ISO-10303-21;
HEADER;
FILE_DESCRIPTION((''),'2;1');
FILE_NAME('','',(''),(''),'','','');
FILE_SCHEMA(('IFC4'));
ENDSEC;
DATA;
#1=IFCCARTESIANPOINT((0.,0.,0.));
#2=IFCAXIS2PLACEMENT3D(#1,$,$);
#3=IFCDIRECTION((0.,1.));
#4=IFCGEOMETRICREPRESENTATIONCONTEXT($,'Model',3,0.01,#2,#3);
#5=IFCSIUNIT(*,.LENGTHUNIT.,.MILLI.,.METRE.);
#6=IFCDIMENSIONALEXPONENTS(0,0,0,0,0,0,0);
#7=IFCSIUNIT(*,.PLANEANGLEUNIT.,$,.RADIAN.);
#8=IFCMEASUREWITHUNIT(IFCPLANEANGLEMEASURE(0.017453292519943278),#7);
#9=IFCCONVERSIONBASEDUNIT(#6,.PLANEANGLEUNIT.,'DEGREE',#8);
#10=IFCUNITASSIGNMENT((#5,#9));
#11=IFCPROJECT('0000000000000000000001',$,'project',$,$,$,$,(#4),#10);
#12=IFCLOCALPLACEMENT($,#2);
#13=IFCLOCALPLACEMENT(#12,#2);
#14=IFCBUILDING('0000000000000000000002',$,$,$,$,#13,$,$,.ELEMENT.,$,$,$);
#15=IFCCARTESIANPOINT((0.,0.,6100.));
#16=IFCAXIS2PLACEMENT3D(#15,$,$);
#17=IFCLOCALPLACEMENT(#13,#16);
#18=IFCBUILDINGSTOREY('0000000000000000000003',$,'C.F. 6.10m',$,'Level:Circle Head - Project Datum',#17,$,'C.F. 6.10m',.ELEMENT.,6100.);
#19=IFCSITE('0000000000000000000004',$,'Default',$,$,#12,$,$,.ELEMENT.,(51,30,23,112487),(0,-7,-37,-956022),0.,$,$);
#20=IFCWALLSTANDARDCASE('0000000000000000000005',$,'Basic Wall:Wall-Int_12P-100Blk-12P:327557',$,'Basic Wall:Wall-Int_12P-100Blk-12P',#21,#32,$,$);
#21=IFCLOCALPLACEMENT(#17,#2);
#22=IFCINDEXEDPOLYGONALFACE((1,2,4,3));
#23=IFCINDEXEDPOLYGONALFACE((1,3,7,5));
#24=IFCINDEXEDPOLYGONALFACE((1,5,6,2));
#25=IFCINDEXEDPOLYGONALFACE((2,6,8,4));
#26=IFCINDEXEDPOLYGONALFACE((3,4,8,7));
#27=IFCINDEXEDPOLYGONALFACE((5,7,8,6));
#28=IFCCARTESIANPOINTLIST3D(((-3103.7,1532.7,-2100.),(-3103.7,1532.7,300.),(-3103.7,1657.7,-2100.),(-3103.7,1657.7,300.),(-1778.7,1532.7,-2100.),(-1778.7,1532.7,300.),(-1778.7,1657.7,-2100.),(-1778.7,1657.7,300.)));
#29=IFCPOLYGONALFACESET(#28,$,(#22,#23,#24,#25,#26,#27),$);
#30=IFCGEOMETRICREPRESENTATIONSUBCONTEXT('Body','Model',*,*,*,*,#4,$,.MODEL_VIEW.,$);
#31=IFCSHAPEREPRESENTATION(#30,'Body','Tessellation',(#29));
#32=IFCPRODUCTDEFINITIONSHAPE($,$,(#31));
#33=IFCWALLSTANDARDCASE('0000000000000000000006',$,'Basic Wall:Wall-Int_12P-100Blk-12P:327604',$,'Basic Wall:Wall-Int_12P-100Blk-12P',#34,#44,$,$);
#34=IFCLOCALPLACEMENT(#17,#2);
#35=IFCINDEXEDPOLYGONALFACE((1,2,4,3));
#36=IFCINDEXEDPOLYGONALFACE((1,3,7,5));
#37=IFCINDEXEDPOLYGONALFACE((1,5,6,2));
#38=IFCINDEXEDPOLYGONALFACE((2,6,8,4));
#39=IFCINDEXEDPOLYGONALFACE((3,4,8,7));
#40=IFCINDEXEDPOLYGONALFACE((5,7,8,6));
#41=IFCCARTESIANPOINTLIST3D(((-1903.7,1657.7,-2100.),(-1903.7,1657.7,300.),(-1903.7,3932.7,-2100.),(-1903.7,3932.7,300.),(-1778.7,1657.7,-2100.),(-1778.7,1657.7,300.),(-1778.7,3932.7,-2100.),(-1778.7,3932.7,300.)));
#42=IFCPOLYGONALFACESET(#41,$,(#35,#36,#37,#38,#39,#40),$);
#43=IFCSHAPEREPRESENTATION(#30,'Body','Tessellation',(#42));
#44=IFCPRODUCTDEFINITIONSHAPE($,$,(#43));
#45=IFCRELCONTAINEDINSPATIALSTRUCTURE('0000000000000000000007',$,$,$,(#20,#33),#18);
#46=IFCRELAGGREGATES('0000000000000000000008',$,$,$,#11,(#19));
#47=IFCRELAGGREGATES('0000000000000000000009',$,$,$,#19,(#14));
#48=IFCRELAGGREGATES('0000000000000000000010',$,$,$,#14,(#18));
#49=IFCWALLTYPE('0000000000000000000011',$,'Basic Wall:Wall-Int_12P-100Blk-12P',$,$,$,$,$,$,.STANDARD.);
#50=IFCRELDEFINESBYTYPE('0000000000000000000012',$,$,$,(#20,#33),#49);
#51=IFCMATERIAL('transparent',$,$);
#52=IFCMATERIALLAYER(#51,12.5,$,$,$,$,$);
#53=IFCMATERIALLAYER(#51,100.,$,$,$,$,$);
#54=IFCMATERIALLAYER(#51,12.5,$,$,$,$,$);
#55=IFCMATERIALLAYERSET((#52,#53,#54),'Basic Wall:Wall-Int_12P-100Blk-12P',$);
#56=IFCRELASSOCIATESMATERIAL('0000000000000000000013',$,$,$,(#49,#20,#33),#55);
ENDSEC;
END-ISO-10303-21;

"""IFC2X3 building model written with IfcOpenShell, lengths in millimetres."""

from ifc_helpers import new_model, entity, si_unit, converted_unit, direction, frame, frame_2d, origin, place, context, subcontext, project, spatial, rectangle, extrude, material, layer, layer_set, layer_usage, type_object, element, save


model = new_model("IFC2X3")

# Units and contexts
model_context = context("Model", 3, precision=0.01, world=origin(), true_north=direction((0.0, 1.0)))
body_context = subcontext(model_context, "Body", "Model", "MODEL_VIEW")
ifc_project = project(units=[si_unit("LENGTHUNIT", "METRE", prefix="MILLI"), converted_unit("PLANEANGLEUNIT", "DEGREE", entity("IfcPlaneAngleMeasure", 0.017453292519943278), si_unit("PLANEANGLEUNIT", "RADIAN"), dimensions=[0, 0, 0, 0, 0, 0, 0])], contexts=[model_context])

# Site, building, storey
site_placement = place(None, origin())
site = spatial("IfcSite", under=ifc_project, at=site_placement, Name="Default", CompositionType="ELEMENT", RefLatitude=(51, 30, 23, 112487), RefLongitude=(0, -7, -37, -956022), RefElevation=0.0)
building_placement = place(site_placement, origin())
building = spatial("IfcBuilding", under=site, at=building_placement, CompositionType="ELEMENT")
storey_placement = place(building_placement, frame((0.0, 0.0, 6100.0)))
storey = spatial("IfcBuildingStorey", under=building, at=storey_placement, Name="C.F. 6.10m", ObjectType="Level:Circle Head - Project Datum", LongName="C.F. 6.10m", CompositionType="ELEMENT", Elevation=6100.0)

# Walls
ifc_material = material(Name="transparent")
ifc_layer_1 = layer(ifc_material, 12.5)
ifc_layer_2 = layer(ifc_material, 100.0)
ifc_layer_3 = layer(ifc_material, 12.5)
ifc_layer_set = layer_set([ifc_layer_1, ifc_layer_2, ifc_layer_3], Name="Basic Wall:Wall-Int_12P-100Blk-12P")
ifc_layer_usage_1 = layer_usage(ifc_layer_set, "AXIS2", "NEGATIVE", 62.5)
wall_type = type_object("IfcWallType", Name="Basic Wall:Wall-Int_12P-100Blk-12P", PredefinedType="STANDARD", material=ifc_layer_set)
wall_1_placement = place(storey_placement, frame((-3103.7, 1595.2, -2100.0)))
element("IfcWallStandardCase", 1, at=wall_1_placement, inside=storey, type_object=wall_type, material=ifc_layer_usage_1, Name="Basic Wall:Wall-Int_12P-100Blk-12P:327557", ObjectType="Basic Wall:Wall-Int_12P-100Blk-12P", context=body_context, shape_type="SweptSolid", body=[
    extrude(rectangle(XDim=1325.0, YDim=125.0, at=frame_2d((662.5, 0.0), x_axis=(-1.0, 0.0))), origin(), (0.0, 0.0, 1.0), 2400.0),
])
ifc_layer_usage_2 = layer_usage(ifc_layer_set, "AXIS2", "NEGATIVE", 62.5)
wall_2_placement = place(storey_placement, frame((-1841.2, 1657.7, -2100.0), z_axis=(0.0, 0.0, 1.0), x_axis=(0.0, 1.0, 0.0)))
element("IfcWallStandardCase", 2, at=wall_2_placement, inside=storey, type_object=wall_type, material=ifc_layer_usage_2, Name="Basic Wall:Wall-Int_12P-100Blk-12P:327604", ObjectType="Basic Wall:Wall-Int_12P-100Blk-12P", context=body_context, shape_type="SweptSolid", body=[
    extrude(rectangle(XDim=2275.0, YDim=125.0, at=frame_2d((1137.5, 0.0), x_axis=(-1.0, 0.0))), origin(), (0.0, 0.0, 1.0), 2400.0),
])

save(model, "model.ifc")
